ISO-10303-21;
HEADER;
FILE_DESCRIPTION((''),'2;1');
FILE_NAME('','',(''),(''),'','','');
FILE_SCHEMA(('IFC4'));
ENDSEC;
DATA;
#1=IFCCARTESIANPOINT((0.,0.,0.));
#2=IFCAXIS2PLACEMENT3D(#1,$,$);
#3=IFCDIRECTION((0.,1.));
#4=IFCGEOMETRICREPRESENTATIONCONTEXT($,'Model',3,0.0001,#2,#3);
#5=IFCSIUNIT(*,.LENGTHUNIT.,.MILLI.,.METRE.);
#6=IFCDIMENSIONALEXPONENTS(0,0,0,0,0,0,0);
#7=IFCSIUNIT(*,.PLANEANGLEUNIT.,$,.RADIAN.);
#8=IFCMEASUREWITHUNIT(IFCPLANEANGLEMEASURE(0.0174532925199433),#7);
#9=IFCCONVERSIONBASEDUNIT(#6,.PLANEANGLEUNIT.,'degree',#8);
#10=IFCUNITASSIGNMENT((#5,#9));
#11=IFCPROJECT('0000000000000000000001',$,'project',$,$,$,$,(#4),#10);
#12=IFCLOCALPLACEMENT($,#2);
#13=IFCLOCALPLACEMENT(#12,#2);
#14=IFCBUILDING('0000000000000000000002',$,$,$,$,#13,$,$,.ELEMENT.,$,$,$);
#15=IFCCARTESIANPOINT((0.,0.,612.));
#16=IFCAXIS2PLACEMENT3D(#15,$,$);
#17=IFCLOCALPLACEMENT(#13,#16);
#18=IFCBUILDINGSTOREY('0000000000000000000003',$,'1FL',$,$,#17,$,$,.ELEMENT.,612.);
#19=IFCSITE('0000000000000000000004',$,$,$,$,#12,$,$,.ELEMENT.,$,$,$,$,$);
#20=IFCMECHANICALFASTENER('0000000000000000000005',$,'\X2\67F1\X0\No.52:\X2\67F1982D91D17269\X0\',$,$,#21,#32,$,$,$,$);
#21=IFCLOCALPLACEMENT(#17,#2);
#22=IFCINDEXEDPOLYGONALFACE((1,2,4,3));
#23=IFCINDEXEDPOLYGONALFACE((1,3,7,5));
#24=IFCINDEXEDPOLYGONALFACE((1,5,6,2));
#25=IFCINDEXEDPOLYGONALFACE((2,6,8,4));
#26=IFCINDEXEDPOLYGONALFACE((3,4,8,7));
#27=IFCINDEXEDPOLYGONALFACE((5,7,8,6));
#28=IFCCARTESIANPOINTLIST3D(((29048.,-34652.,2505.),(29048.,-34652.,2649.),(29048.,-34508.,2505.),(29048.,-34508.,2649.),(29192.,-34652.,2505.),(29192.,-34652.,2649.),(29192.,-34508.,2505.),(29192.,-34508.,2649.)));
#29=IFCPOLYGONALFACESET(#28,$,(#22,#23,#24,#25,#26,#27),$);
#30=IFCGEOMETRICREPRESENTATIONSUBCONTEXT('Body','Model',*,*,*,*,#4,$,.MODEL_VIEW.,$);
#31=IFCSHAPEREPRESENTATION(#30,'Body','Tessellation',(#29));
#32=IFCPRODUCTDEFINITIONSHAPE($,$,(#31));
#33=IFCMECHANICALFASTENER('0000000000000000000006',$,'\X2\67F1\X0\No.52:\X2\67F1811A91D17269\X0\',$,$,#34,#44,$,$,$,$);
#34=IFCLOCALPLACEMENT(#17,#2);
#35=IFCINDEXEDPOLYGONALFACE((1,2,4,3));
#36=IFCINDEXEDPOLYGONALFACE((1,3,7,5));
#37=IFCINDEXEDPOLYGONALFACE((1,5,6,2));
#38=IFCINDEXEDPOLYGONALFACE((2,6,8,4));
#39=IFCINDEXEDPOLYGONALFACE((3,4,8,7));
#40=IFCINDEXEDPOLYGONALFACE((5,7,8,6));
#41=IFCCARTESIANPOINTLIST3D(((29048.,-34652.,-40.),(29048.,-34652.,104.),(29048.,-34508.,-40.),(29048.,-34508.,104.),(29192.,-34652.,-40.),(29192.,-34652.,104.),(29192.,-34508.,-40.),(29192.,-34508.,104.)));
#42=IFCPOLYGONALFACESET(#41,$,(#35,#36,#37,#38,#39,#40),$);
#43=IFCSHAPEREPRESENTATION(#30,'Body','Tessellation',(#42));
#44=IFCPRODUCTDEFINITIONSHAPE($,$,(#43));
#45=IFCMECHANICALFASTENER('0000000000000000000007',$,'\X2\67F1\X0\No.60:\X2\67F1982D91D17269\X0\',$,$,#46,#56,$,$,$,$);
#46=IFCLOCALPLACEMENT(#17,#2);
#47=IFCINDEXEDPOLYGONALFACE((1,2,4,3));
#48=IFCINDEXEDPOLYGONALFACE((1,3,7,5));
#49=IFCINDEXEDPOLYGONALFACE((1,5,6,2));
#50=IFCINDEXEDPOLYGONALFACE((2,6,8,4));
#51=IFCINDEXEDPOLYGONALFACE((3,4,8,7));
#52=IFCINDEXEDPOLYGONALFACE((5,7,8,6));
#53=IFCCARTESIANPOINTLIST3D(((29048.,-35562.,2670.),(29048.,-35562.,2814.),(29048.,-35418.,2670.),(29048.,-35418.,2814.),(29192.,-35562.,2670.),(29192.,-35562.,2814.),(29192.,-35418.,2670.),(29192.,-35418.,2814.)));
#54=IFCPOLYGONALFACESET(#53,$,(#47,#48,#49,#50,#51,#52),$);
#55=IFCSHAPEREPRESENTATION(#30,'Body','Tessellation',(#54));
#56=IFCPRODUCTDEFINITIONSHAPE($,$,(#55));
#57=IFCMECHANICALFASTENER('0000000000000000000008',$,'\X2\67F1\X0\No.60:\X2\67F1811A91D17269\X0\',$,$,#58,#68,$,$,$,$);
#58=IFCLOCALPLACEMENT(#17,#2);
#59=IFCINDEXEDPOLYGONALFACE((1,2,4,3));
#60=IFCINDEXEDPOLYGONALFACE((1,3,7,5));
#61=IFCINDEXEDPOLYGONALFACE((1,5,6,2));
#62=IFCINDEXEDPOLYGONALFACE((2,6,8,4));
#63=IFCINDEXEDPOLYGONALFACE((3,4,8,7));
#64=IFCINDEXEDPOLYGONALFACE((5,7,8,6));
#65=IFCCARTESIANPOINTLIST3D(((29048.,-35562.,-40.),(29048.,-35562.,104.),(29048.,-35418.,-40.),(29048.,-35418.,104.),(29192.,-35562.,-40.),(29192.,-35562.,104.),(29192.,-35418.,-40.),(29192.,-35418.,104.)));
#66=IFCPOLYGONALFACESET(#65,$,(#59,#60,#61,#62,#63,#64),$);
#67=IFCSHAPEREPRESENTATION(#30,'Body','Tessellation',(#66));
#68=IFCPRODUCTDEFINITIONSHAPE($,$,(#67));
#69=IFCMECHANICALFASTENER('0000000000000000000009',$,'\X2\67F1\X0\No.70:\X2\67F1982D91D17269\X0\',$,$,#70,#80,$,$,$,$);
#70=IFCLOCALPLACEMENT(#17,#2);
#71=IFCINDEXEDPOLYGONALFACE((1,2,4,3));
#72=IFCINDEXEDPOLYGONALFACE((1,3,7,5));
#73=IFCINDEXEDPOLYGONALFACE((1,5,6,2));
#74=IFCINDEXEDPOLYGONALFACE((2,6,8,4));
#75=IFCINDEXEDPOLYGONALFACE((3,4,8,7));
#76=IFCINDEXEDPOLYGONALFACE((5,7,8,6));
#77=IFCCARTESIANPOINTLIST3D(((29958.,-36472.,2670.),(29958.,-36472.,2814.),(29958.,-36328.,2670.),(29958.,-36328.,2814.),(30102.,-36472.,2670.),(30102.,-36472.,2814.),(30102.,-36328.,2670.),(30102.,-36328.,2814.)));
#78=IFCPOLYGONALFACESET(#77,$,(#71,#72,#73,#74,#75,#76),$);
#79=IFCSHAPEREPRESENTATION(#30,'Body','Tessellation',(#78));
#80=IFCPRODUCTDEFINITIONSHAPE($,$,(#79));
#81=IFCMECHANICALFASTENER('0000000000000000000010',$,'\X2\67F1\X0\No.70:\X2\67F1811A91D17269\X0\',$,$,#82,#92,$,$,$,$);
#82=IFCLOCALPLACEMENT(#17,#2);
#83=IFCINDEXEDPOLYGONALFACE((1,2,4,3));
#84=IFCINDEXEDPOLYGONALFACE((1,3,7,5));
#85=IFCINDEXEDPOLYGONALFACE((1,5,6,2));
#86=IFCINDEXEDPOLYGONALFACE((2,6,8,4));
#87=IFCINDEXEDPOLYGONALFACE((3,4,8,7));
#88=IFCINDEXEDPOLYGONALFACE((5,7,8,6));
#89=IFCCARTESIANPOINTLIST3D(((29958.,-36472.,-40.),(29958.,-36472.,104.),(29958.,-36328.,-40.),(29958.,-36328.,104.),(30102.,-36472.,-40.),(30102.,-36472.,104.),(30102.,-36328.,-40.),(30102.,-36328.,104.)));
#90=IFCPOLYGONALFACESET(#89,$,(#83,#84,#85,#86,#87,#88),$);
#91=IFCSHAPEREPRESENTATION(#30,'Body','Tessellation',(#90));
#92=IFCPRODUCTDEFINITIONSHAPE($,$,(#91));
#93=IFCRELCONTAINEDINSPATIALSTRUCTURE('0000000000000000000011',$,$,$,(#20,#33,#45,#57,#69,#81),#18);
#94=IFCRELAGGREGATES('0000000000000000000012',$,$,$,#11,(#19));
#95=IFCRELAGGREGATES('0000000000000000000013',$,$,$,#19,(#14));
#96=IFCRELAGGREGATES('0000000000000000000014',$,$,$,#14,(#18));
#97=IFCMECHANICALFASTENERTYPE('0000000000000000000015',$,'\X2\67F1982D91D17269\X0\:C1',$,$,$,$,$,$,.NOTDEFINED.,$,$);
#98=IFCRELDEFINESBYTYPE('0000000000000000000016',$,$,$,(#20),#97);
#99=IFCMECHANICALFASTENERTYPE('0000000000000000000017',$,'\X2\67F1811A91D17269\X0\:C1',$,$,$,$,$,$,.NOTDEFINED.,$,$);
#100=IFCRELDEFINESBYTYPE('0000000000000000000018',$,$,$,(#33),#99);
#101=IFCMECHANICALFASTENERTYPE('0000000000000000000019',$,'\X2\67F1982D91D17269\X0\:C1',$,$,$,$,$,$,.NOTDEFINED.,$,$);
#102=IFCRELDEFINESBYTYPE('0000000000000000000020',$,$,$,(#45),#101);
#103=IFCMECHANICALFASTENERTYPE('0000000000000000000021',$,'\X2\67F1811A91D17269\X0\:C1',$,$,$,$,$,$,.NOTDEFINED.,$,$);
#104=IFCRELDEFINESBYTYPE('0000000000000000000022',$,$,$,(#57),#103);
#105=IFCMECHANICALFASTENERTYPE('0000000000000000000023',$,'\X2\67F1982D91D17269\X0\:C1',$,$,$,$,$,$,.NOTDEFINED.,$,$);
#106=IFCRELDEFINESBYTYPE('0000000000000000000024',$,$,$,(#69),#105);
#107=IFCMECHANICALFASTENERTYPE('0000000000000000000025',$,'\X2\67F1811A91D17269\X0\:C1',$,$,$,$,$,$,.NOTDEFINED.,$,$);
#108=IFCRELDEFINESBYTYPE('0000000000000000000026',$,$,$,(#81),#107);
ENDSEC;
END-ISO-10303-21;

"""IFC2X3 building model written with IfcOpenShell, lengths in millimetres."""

from ifc_helpers import new_model, entity, si_unit, converted_unit, direction, frame, origin, origin_with_axes, origin_2d, place, context, subcontext, project, spatial, rectangle, extrude, type_object, element, save


model = new_model("IFC2X3")

# Units and contexts
model_context = context("Model", 3, precision=0.0001, world=origin(), true_north=direction((0.0, 1.0)))
body_context = subcontext(model_context, "Body", "Model", "MODEL_VIEW")
ifc_project = project(units=[si_unit("LENGTHUNIT", "METRE", prefix="MILLI"), converted_unit("PLANEANGLEUNIT", "degree", entity("IfcPlaneAngleMeasure", 0.0174532925199433), si_unit("PLANEANGLEUNIT", "RADIAN"), dimensions=[0, 0, 0, 0, 0, 0, 0])], contexts=[model_context])

# Site, building, storey
site_placement = place(None, origin())
site = spatial("IfcSite", under=ifc_project, at=site_placement, CompositionType="ELEMENT")
building_placement = place(site_placement, origin())
building = spatial("IfcBuilding", under=site, at=building_placement, CompositionType="ELEMENT")
storey_placement = place(building_placement, frame((0.0, 0.0, 612.0)))
storey = spatial("IfcBuildingStorey", under=building, at=storey_placement, Name="1FL", CompositionType="ELEMENT", Elevation=612.0)

# Mechanical fasteners
mechanical_fastener_type_1 = type_object("IfcMechanicalFastenerType", Name="柱頭金物:C1")
mechanical_fastener_1_placement = place(storey_placement, frame((29120.0, -34580.0, 2505.0)))
element("IfcMechanicalFastener", 1, at=mechanical_fastener_1_placement, inside=storey, type_object=mechanical_fastener_type_1, Name="柱No.52:柱頭金物", context=body_context, shape_type="SweptSolid", body=[
    extrude(rectangle(XDim=144.0, YDim=144.0, at=origin_2d()), origin_with_axes(), (0.0, 0.0, 1.0), 144.0),
])
mechanical_fastener_type_2 = type_object("IfcMechanicalFastenerType", Name="柱脚金物:C1")
mechanical_fastener_2_placement = place(storey_placement, frame((29120.0, -34580.0, -40.0)))
element("IfcMechanicalFastener", 2, at=mechanical_fastener_2_placement, inside=storey, type_object=mechanical_fastener_type_2, Name="柱No.52:柱脚金物", context=body_context, shape_type="SweptSolid", body=[
    extrude(rectangle(XDim=144.0, YDim=144.0, at=origin_2d()), origin_with_axes(), (0.0, 0.0, 1.0), 144.0),
])
mechanical_fastener_type_3 = type_object("IfcMechanicalFastenerType", Name="柱頭金物:C1")
mechanical_fastener_3_placement = place(storey_placement, frame((29120.0, -35490.0, 2670.0)))
element("IfcMechanicalFastener", 3, at=mechanical_fastener_3_placement, inside=storey, type_object=mechanical_fastener_type_3, Name="柱No.60:柱頭金物", context=body_context, shape_type="SweptSolid", body=[
    extrude(rectangle(XDim=144.0, YDim=144.0, at=origin_2d()), origin_with_axes(), (0.0, 0.0, 1.0), 144.0),
])
mechanical_fastener_type_4 = type_object("IfcMechanicalFastenerType", Name="柱脚金物:C1")
mechanical_fastener_4_placement = place(storey_placement, frame((29120.0, -35490.0, -40.0)))
element("IfcMechanicalFastener", 4, at=mechanical_fastener_4_placement, inside=storey, type_object=mechanical_fastener_type_4, Name="柱No.60:柱脚金物", context=body_context, shape_type="SweptSolid", body=[
    extrude(rectangle(XDim=144.0, YDim=144.0, at=origin_2d()), origin_with_axes(), (0.0, 0.0, 1.0), 144.0),
])
mechanical_fastener_type_5 = type_object("IfcMechanicalFastenerType", Name="柱頭金物:C1")
mechanical_fastener_5_placement = place(storey_placement, frame((30030.0, -36400.0, 2670.0)))
element("IfcMechanicalFastener", 5, at=mechanical_fastener_5_placement, inside=storey, type_object=mechanical_fastener_type_5, Name="柱No.70:柱頭金物", context=body_context, shape_type="SweptSolid", body=[
    extrude(rectangle(XDim=144.0, YDim=144.0, at=origin_2d()), origin_with_axes(), (0.0, 0.0, 1.0), 144.0),
])
mechanical_fastener_type_6 = type_object("IfcMechanicalFastenerType", Name="柱脚金物:C1")
mechanical_fastener_6_placement = place(storey_placement, frame((30030.0, -36400.0, -40.0)))
element("IfcMechanicalFastener", 6, at=mechanical_fastener_6_placement, inside=storey, type_object=mechanical_fastener_type_6, Name="柱No.70:柱脚金物", context=body_context, shape_type="SweptSolid", body=[
    extrude(rectangle(XDim=144.0, YDim=144.0, at=origin_2d()), origin_with_axes(), (0.0, 0.0, 1.0), 144.0),
])

save(model, "model.ifc")
